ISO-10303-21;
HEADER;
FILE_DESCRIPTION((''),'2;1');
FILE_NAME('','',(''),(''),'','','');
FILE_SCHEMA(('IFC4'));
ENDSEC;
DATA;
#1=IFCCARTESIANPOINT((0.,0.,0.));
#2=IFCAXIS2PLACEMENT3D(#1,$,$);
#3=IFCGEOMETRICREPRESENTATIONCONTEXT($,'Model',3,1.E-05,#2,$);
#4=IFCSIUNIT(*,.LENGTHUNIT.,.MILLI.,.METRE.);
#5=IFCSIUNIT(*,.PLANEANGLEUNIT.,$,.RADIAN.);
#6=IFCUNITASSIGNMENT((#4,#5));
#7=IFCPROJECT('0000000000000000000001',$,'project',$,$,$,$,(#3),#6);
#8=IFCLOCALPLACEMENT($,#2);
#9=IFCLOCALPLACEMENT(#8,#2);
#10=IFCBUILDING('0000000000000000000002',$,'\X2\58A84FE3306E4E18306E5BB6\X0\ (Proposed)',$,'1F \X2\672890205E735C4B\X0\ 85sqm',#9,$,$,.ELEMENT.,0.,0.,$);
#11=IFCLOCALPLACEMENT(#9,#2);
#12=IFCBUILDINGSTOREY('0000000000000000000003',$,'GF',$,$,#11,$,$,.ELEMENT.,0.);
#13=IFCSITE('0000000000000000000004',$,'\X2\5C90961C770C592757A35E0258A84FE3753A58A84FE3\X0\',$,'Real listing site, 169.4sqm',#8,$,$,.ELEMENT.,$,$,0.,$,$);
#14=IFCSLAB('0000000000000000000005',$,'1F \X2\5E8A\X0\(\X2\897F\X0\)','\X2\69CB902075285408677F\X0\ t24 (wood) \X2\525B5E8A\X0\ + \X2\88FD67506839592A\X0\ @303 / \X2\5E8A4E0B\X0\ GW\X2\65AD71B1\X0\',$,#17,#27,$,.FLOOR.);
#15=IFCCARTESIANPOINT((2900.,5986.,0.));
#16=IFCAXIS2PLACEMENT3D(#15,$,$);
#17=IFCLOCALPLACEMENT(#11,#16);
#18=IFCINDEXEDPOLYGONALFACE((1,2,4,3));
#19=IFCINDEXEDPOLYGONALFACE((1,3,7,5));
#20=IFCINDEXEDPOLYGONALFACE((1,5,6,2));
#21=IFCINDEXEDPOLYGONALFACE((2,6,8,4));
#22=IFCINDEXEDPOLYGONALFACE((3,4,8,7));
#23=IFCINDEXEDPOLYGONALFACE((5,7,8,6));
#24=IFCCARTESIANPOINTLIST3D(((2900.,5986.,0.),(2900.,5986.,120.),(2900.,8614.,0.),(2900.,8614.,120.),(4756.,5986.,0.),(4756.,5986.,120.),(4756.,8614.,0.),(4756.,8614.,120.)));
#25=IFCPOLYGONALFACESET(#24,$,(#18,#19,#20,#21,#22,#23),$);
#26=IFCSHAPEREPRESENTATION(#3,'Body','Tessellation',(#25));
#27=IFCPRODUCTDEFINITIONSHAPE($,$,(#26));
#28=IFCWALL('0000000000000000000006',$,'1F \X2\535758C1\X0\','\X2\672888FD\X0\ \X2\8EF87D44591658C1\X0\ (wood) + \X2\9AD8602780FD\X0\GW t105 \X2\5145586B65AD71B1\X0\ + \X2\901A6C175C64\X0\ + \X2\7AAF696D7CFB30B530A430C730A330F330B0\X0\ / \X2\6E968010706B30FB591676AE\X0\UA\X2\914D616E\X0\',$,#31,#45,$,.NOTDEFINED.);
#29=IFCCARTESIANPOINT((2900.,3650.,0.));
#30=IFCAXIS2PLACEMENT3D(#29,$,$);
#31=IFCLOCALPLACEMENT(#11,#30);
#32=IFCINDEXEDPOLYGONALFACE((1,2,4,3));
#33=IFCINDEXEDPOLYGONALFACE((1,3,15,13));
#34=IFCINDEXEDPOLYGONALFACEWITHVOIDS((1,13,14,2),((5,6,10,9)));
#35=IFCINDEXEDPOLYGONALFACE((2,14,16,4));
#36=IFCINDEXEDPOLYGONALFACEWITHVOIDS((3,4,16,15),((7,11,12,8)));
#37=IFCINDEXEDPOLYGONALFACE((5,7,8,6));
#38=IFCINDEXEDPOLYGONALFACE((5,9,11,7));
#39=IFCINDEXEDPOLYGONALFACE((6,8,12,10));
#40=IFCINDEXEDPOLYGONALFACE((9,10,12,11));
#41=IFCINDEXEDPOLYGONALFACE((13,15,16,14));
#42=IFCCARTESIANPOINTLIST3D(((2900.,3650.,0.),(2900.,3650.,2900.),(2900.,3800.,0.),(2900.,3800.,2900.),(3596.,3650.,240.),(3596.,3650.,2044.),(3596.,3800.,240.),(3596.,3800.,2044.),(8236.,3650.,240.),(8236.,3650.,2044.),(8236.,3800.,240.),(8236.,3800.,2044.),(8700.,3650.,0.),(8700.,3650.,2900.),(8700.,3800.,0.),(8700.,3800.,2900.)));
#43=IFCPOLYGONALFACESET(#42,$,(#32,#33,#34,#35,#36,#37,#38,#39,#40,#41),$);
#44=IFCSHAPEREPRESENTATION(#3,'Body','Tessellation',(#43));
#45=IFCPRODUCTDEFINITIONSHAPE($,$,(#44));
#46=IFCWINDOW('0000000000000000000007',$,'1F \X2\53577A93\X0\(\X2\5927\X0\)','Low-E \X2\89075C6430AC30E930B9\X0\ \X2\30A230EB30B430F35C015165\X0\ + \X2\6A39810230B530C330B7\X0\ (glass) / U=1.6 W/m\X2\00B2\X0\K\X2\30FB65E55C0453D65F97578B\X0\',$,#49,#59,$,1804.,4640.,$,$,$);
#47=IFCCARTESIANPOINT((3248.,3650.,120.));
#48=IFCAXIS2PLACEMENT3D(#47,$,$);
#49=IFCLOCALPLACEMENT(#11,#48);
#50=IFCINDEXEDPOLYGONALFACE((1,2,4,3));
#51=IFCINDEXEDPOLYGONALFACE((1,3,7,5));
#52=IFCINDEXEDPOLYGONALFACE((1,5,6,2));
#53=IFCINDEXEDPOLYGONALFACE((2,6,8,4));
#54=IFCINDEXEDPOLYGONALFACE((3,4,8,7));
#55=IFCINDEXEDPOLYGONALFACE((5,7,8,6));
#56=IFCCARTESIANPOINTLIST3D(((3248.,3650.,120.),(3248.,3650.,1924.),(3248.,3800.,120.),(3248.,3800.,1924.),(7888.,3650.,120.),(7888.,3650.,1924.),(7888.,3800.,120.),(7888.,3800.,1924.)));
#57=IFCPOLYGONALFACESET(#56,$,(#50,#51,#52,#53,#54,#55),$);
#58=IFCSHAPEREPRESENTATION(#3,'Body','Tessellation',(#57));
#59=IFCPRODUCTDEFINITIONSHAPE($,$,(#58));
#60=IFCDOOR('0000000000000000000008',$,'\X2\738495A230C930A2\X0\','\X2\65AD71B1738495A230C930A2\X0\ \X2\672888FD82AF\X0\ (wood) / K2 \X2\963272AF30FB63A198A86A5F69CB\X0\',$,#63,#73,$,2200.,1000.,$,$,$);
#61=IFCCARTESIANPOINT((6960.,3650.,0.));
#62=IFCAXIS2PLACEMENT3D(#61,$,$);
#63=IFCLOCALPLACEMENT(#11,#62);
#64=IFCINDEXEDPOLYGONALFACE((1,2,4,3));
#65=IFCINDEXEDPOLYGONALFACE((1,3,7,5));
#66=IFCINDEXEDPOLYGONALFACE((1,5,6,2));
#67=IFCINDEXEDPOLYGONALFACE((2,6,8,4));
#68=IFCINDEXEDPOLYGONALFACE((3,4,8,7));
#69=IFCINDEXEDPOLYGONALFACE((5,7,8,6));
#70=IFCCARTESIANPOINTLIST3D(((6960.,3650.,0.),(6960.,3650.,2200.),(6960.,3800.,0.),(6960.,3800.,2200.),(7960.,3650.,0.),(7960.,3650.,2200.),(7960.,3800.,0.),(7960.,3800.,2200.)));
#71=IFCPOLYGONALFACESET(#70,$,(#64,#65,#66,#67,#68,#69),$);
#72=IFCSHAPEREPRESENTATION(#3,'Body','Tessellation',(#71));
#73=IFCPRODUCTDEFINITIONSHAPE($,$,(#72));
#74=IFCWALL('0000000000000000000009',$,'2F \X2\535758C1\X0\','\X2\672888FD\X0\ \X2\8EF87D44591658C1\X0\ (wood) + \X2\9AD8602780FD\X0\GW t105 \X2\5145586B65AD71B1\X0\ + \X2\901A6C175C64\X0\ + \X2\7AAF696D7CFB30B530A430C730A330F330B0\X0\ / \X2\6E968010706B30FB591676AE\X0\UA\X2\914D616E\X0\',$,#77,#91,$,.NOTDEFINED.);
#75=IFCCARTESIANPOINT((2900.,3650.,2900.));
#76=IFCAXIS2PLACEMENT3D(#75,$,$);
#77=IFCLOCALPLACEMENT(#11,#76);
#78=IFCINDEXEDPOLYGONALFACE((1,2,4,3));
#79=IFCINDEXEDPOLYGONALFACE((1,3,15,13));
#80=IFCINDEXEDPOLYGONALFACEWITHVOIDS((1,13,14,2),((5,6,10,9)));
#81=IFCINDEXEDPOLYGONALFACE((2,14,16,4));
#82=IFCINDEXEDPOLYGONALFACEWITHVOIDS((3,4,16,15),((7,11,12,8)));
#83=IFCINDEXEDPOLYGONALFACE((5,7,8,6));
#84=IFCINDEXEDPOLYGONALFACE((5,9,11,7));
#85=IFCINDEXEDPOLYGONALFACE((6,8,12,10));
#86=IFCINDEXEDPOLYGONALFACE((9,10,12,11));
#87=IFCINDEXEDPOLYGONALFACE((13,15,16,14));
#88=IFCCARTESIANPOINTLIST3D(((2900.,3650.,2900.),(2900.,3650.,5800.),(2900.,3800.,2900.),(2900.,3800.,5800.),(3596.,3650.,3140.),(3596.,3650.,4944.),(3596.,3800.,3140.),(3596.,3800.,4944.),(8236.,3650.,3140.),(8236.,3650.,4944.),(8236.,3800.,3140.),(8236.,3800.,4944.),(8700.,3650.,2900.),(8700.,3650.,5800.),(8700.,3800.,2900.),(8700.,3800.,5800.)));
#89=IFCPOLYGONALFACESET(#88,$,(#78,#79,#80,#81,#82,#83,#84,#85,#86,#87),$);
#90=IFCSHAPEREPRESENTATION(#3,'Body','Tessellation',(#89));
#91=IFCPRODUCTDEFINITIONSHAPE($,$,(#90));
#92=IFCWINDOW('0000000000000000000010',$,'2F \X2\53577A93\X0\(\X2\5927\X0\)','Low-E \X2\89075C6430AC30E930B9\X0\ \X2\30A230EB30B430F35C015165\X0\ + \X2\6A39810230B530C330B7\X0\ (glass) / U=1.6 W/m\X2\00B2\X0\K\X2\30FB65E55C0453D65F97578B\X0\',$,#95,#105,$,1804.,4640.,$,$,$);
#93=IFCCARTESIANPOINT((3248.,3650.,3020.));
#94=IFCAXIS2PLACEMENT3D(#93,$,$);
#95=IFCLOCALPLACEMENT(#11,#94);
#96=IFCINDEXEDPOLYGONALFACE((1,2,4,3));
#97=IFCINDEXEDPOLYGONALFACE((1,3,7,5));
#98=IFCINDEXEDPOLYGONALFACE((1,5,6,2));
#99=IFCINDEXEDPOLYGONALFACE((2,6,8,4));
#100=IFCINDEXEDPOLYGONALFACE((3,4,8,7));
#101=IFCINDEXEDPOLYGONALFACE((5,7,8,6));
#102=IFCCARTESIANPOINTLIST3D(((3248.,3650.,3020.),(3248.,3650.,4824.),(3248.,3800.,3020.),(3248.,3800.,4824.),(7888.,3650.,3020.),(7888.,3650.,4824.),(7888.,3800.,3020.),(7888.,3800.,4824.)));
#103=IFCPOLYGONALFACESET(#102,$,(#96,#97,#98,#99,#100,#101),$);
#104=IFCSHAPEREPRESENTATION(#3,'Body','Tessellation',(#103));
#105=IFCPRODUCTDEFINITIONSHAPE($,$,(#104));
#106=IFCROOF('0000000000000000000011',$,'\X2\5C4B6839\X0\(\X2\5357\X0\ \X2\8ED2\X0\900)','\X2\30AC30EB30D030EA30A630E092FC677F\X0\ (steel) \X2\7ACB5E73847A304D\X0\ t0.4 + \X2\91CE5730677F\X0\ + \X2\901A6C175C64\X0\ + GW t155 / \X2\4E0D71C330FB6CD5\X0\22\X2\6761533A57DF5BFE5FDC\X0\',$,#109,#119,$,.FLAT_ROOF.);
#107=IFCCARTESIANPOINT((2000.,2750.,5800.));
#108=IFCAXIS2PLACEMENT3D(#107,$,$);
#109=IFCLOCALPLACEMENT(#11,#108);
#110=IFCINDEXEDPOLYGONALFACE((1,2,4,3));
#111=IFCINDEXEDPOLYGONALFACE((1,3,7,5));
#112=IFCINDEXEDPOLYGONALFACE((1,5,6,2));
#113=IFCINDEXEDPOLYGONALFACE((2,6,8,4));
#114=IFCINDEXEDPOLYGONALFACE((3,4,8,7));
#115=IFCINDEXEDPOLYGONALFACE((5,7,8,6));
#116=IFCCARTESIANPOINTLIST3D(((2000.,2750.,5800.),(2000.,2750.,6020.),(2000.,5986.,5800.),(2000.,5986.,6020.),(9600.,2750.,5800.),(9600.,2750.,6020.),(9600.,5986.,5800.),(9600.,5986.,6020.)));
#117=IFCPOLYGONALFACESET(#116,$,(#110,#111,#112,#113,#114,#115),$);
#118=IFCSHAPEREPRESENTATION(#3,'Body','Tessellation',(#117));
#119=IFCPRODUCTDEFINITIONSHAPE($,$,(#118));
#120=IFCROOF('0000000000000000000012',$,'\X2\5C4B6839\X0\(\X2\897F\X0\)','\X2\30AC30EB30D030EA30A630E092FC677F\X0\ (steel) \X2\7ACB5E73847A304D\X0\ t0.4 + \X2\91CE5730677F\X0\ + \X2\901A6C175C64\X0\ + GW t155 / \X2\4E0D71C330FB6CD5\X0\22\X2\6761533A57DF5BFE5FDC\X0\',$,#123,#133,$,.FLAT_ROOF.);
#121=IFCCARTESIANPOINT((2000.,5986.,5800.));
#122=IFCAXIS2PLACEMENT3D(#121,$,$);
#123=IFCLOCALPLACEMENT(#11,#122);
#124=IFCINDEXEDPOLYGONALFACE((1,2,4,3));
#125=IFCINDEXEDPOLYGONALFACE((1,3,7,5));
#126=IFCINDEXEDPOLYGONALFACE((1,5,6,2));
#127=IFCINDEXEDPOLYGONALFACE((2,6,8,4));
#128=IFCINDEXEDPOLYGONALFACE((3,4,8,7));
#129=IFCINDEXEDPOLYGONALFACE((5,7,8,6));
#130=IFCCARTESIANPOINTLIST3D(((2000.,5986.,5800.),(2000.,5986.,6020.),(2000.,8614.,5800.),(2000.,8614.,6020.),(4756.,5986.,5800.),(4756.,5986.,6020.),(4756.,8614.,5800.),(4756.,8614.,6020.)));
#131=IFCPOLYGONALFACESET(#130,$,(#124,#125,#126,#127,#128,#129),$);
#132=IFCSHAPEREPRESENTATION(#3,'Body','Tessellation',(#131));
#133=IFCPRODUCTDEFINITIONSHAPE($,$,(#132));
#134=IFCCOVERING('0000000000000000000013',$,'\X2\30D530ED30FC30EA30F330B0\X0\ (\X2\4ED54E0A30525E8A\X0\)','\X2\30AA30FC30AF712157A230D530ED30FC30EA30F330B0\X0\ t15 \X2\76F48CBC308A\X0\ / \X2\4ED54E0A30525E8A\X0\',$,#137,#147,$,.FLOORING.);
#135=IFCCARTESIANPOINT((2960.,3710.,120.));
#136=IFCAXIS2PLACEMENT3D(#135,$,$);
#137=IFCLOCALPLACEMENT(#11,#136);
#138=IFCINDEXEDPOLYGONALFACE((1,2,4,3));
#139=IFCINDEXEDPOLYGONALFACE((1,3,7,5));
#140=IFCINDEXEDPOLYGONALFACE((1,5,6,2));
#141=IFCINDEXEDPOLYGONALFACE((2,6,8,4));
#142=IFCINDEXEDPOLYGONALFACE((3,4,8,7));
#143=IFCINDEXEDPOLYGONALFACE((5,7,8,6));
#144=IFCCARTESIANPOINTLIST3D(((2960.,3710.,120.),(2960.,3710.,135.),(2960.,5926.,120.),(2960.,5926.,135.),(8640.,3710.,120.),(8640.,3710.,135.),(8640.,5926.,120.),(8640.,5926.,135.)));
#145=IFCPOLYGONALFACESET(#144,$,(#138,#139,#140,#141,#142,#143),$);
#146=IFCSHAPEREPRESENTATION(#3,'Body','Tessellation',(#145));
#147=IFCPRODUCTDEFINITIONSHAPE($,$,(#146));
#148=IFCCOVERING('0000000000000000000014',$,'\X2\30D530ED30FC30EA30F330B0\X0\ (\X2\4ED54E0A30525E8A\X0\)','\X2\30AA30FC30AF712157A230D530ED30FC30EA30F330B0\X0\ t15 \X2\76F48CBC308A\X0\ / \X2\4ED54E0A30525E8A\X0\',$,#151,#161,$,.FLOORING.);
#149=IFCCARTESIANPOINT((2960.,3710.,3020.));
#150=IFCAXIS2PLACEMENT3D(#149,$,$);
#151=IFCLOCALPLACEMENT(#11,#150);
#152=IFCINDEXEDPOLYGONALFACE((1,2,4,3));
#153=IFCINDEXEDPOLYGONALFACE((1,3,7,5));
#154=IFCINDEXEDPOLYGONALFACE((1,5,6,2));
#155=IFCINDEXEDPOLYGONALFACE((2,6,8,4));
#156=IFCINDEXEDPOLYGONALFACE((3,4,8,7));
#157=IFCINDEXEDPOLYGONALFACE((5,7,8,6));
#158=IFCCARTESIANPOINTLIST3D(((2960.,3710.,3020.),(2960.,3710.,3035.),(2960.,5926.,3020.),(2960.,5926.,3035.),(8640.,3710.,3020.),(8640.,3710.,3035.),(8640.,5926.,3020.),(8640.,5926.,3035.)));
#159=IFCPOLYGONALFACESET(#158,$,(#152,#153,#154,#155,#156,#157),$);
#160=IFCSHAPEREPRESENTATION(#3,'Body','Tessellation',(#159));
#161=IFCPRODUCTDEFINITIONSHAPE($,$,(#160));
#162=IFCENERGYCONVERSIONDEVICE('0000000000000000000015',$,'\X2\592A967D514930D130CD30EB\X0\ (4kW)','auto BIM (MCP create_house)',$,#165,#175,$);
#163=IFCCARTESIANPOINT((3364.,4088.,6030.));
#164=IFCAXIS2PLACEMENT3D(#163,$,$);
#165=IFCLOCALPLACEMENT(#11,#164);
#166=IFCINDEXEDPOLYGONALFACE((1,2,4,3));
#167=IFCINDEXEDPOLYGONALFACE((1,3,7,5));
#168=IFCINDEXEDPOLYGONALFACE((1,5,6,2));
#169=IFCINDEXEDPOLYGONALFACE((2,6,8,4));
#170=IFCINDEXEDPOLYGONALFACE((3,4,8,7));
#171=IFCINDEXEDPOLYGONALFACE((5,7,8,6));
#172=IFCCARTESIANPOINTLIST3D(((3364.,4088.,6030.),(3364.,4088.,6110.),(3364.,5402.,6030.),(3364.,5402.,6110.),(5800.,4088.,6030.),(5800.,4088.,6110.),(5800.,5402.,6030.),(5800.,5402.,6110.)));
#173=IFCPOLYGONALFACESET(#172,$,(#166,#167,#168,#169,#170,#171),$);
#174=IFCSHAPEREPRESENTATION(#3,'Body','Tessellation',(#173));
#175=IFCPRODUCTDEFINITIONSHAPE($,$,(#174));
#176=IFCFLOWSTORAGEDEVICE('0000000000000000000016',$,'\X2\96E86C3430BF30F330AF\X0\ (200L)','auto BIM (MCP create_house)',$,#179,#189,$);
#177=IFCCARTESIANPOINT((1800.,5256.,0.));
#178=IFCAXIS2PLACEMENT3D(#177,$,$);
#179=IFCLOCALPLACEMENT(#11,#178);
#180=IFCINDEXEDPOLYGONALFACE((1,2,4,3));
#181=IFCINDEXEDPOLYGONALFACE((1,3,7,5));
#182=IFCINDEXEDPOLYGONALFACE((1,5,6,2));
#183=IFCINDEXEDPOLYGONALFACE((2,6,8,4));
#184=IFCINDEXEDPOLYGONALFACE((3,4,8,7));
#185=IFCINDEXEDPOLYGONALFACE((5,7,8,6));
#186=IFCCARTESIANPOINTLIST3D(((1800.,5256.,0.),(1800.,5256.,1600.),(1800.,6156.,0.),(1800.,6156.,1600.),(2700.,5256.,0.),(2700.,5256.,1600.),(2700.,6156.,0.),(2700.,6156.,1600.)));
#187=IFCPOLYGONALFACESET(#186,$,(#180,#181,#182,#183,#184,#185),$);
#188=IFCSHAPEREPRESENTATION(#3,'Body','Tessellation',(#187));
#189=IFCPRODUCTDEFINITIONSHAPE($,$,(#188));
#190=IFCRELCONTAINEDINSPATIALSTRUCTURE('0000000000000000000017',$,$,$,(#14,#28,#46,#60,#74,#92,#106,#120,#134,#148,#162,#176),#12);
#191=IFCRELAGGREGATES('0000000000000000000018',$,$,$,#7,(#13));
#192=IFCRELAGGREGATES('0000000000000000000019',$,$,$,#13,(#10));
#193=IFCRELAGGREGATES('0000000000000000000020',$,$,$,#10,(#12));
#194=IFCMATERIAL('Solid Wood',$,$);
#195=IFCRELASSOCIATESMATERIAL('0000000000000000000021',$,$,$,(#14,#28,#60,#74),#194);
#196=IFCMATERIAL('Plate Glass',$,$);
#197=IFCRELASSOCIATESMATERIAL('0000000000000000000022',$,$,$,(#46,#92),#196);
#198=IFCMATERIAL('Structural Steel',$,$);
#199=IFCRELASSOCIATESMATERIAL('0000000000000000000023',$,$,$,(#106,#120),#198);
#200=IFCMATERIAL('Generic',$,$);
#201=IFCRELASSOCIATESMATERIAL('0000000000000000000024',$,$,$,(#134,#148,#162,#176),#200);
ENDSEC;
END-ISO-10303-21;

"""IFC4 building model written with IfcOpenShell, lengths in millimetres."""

from ifc_helpers import new_model, si_unit, frame, frame_2d, origin, place, context, project, spatial, rectangle, extrude, material, element, fill, save


model = new_model("IFC4")

# Units and contexts
model_context = context("Model", 3, precision=1e-05, world=origin())
ifc_project = project(units=[si_unit("LENGTHUNIT", "METRE", prefix="MILLI"), si_unit("PLANEANGLEUNIT", "RADIAN")], contexts=[model_context])

# Site, building, storey
site_placement = place(None, origin())
site = spatial("IfcSite", under=ifc_project, at=site_placement, Name="岐阜県大垣市墨俣町墨俣", ObjectType="Real listing site, 169.4sqm", CompositionType="ELEMENT", RefElevation=0.0)
building_placement = place(site_placement, origin())
building = spatial("IfcBuilding", under=site, at=building_placement, Name="墨俣の丘の家 (Proposed)", ObjectType="1F 木造平屋 85sqm", CompositionType="ELEMENT", ElevationOfRefHeight=0.0, ElevationOfTerrain=0.0)
storey_placement = place(building_placement, origin())
storey = spatial("IfcBuildingStorey", under=building, at=storey_placement, Name="GF", CompositionType="ELEMENT", Elevation=0.0)

# Slab
ifc_material_1 = material(Name="Solid Wood")
slab_1_placement = place(storey_placement, frame((2900.0, 5986.0, 0.0)))
element("IfcSlab", 1, at=slab_1_placement, inside=storey, material=ifc_material_1, Name="1F 床(西)", Description="構造用合板 t24 (wood) 剛床 + 製材根太 @303 / 床下 GW断熱", PredefinedType="FLOOR", context=model_context, shape_type="SweptSolid", body=[
    extrude(rectangle(XDim=1856.0, YDim=2628.0, at=frame_2d((928.0, 1314.0))), frame((2900.0, 5986.0, 0.0)), (0.0, 0.0, 1.0), 120.0),
])
ifc_material_2 = material(Name="Generic")

# Wall, openings, window, door
wall_1_placement = place(storey_placement, frame((2900.0, 3650.0, 0.0)))
wall_1 = element("IfcWall", 2, at=wall_1_placement, inside=storey, material=ifc_material_1, Name="1F 南壁", Description="木製 軸組外壁 (wood) + 高性能GW t105 充填断熱 + 通気層 + 窯業系サイディング / 準耐火・外皮UA配慮", PredefinedType="NOTDEFINED", context=model_context, shape_type="SweptSolid", body=[
    extrude(rectangle(XDim=5800.0, YDim=150.0, at=frame_2d((2900.0, 75.0))), frame((2900.0, 3650.0, 0.0)), (0.0, 0.0, 1.0), 2900.0),
])
opening_1_placement = place(storey_placement, frame((3248.0, 3650.0, 120.0)))
opening_1 = element("IfcOpeningElement", 3, at=opening_1_placement, cuts=wall_1, PredefinedType="NOTDEFINED", context=model_context, shape_type="SweptSolid", body=[
    extrude(rectangle(XDim=4640.0, YDim=150.0, at=frame_2d((2320.0, 75.0))), frame((3248.0, 3650.0, 120.0)), (0.0, 0.0, 1.0), 1804.0),
])
opening_2_placement = place(storey_placement, frame((6960.0, 3650.0, 0.0)))
opening_2 = element("IfcOpeningElement", 4, at=opening_2_placement, cuts=wall_1, PredefinedType="NOTDEFINED", context=model_context, shape_type="SweptSolid", body=[
    extrude(rectangle(XDim=1000.0, YDim=150.0, at=frame_2d((500.0, 75.0))), frame((6960.0, 3650.0, 0.0)), (0.0, 0.0, 1.0), 2200.0),
])
ifc_material_3 = material(Name="Plate Glass")
window_1_placement = place(storey_placement, frame((3248.0, 3650.0, 120.0)))
window_1 = element("IfcWindow", 5, at=window_1_placement, inside=storey, material=ifc_material_3, Name="1F 南窓(大)", Description="Low-E 複層ガラス アルゴン封入 + 樹脂サッシ (glass) / U=1.6 W/m²K・日射取得型", OverallHeight=1804.0, OverallWidth=4640.0, context=model_context, shape_type="SweptSolid", body=[
    extrude(rectangle(XDim=4640.0, YDim=150.0, at=frame_2d((2320.0, 75.0))), frame((3248.0, 3650.0, 120.0)), (0.0, 0.0, 1.0), 1804.0),
])
fill(opening_1, window_1)
door_placement = place(storey_placement, frame((6960.0, 3650.0, 0.0)))
door = element("IfcDoor", 6, at=door_placement, inside=storey, material=ifc_material_1, Name="玄関ドア", Description="断熱玄関ドア 木製芯 (wood) / K2 防犯・採風機構", OverallHeight=2200.0, OverallWidth=1000.0, context=model_context, shape_type="SweptSolid", body=[
    extrude(rectangle(XDim=1000.0, YDim=150.0, at=frame_2d((500.0, 75.0))), frame((6960.0, 3650.0, 0.0)), (0.0, 0.0, 1.0), 2200.0),
])
fill(opening_2, door)

# Wall, opening, window
wall_2_placement = place(storey_placement, frame((2900.0, 3650.0, 2900.0)))
wall_2 = element("IfcWall", 7, at=wall_2_placement, inside=storey, material=ifc_material_1, Name="2F 南壁", Description="木製 軸組外壁 (wood) + 高性能GW t105 充填断熱 + 通気層 + 窯業系サイディング / 準耐火・外皮UA配慮", PredefinedType="NOTDEFINED", context=model_context, shape_type="SweptSolid", body=[
    extrude(rectangle(XDim=5800.0, YDim=150.0, at=frame_2d((2900.0, 75.0))), frame((2900.0, 3650.0, 2900.0)), (0.0, 0.0, 1.0), 2900.0),
])
opening_3_placement = place(storey_placement, frame((3248.0, 3650.0, 3020.0)))
opening_3 = element("IfcOpeningElement", 8, at=opening_3_placement, cuts=wall_2, PredefinedType="NOTDEFINED", context=model_context, shape_type="SweptSolid", body=[
    extrude(rectangle(XDim=4640.0, YDim=150.0, at=frame_2d((2320.0, 75.0))), frame((3248.0, 3650.0, 3020.0)), (0.0, 0.0, 1.0), 1804.0),
])
window_2_placement = place(storey_placement, frame((3248.0, 3650.0, 3020.0)))
window_2 = element("IfcWindow", 9, at=window_2_placement, inside=storey, material=ifc_material_3, Name="2F 南窓(大)", Description="Low-E 複層ガラス アルゴン封入 + 樹脂サッシ (glass) / U=1.6 W/m²K・日射取得型", OverallHeight=1804.0, OverallWidth=4640.0, context=model_context, shape_type="SweptSolid", body=[
    extrude(rectangle(XDim=4640.0, YDim=150.0, at=frame_2d((2320.0, 75.0))), frame((3248.0, 3650.0, 3020.0)), (0.0, 0.0, 1.0), 1804.0),
])
fill(opening_3, window_2)

# Roofs
ifc_material_4 = material(Name="Structural Steel")
roof_1_placement = place(storey_placement, frame((2000.0, 2750.0, 5800.0)))
element("IfcRoof", 10, at=roof_1_placement, inside=storey, material=ifc_material_4, Name="屋根(南 軒900)", Description="ガルバリウム鋼板 (steel) 立平葺き t0.4 + 野地板 + 通気層 + GW t155 / 不燃・法22条区域対応", PredefinedType="FLAT_ROOF", context=model_context, shape_type="SweptSolid", body=[
    extrude(rectangle(XDim=7600.0, YDim=3236.0, at=frame_2d((3800.0, 1618.0))), frame((2000.0, 2750.0, 5800.0)), (0.0, 0.0, 1.0), 220.0),
])
roof_2_placement = place(storey_placement, frame((2000.0, 5986.0, 5800.0)))
element("IfcRoof", 11, at=roof_2_placement, inside=storey, material=ifc_material_4, Name="屋根(西)", Description="ガルバリウム鋼板 (steel) 立平葺き t0.4 + 野地板 + 通気層 + GW t155 / 不燃・法22条区域対応", PredefinedType="FLAT_ROOF", context=model_context, shape_type="SweptSolid", body=[
    extrude(rectangle(XDim=2756.0, YDim=2628.0, at=frame_2d((1378.0, 1314.0))), frame((2000.0, 5986.0, 5800.0)), (0.0, 0.0, 1.0), 220.0),
])

# Coverings
covering_1_placement = place(storey_placement, frame((2960.0, 3710.0, 120.0)))
element("IfcCovering", 12, at=covering_1_placement, inside=storey, material=ifc_material_2, Name="フローリング (仕上げ床)", Description="オーク無垢フローリング t15 直貼り / 仕上げ床", PredefinedType="FLOORING", context=model_context, shape_type="SweptSolid", body=[
    extrude(rectangle(XDim=5680.0, YDim=2216.0, at=frame_2d((2840.0, 1108.0))), frame((2960.0, 3710.0, 120.0)), (0.0, 0.0, 1.0), 15.0),
])
covering_2_placement = place(storey_placement, frame((2960.0, 3710.0, 3020.0)))
element("IfcCovering", 13, at=covering_2_placement, inside=storey, material=ifc_material_2, Name="フローリング (仕上げ床)", Description="オーク無垢フローリング t15 直貼り / 仕上げ床", PredefinedType="FLOORING", context=model_context, shape_type="SweptSolid", body=[
    extrude(rectangle(XDim=5680.0, YDim=2216.0, at=frame_2d((2840.0, 1108.0))), frame((2960.0, 3710.0, 3020.0)), (0.0, 0.0, 1.0), 15.0),
])

# Energy conversion device
energy_conversion_device_placement = place(storey_placement, frame((3364.0, 4088.0, 6030.0)))
element("IfcEnergyConversionDevice", 14, at=energy_conversion_device_placement, inside=storey, material=ifc_material_2, Name="太陽光パネル (4kW)", Description="auto BIM (MCP create_house)", context=model_context, shape_type="SweptSolid", body=[
    extrude(rectangle(XDim=2436.0, YDim=1314.0, at=frame_2d((1218.0, 657.0))), frame((3364.0, 4088.0, 6030.0)), (0.0, 0.0, 1.0), 80.0),
])

# Flow storage device
flow_storage_device_placement = place(storey_placement, frame((1800.0, 5256.0, 0.0)))
element("IfcFlowStorageDevice", 15, at=flow_storage_device_placement, inside=storey, material=ifc_material_2, Name="雨水タンク (200L)", Description="auto BIM (MCP create_house)", context=model_context, shape_type="SweptSolid", body=[
    extrude(rectangle(XDim=900.0, YDim=900.0, at=frame_2d((450.0, 450.0))), frame((1800.0, 5256.0, 0.0)), (0.0, 0.0, 1.0), 1600.0),
])

save(model, "model.ifc")
